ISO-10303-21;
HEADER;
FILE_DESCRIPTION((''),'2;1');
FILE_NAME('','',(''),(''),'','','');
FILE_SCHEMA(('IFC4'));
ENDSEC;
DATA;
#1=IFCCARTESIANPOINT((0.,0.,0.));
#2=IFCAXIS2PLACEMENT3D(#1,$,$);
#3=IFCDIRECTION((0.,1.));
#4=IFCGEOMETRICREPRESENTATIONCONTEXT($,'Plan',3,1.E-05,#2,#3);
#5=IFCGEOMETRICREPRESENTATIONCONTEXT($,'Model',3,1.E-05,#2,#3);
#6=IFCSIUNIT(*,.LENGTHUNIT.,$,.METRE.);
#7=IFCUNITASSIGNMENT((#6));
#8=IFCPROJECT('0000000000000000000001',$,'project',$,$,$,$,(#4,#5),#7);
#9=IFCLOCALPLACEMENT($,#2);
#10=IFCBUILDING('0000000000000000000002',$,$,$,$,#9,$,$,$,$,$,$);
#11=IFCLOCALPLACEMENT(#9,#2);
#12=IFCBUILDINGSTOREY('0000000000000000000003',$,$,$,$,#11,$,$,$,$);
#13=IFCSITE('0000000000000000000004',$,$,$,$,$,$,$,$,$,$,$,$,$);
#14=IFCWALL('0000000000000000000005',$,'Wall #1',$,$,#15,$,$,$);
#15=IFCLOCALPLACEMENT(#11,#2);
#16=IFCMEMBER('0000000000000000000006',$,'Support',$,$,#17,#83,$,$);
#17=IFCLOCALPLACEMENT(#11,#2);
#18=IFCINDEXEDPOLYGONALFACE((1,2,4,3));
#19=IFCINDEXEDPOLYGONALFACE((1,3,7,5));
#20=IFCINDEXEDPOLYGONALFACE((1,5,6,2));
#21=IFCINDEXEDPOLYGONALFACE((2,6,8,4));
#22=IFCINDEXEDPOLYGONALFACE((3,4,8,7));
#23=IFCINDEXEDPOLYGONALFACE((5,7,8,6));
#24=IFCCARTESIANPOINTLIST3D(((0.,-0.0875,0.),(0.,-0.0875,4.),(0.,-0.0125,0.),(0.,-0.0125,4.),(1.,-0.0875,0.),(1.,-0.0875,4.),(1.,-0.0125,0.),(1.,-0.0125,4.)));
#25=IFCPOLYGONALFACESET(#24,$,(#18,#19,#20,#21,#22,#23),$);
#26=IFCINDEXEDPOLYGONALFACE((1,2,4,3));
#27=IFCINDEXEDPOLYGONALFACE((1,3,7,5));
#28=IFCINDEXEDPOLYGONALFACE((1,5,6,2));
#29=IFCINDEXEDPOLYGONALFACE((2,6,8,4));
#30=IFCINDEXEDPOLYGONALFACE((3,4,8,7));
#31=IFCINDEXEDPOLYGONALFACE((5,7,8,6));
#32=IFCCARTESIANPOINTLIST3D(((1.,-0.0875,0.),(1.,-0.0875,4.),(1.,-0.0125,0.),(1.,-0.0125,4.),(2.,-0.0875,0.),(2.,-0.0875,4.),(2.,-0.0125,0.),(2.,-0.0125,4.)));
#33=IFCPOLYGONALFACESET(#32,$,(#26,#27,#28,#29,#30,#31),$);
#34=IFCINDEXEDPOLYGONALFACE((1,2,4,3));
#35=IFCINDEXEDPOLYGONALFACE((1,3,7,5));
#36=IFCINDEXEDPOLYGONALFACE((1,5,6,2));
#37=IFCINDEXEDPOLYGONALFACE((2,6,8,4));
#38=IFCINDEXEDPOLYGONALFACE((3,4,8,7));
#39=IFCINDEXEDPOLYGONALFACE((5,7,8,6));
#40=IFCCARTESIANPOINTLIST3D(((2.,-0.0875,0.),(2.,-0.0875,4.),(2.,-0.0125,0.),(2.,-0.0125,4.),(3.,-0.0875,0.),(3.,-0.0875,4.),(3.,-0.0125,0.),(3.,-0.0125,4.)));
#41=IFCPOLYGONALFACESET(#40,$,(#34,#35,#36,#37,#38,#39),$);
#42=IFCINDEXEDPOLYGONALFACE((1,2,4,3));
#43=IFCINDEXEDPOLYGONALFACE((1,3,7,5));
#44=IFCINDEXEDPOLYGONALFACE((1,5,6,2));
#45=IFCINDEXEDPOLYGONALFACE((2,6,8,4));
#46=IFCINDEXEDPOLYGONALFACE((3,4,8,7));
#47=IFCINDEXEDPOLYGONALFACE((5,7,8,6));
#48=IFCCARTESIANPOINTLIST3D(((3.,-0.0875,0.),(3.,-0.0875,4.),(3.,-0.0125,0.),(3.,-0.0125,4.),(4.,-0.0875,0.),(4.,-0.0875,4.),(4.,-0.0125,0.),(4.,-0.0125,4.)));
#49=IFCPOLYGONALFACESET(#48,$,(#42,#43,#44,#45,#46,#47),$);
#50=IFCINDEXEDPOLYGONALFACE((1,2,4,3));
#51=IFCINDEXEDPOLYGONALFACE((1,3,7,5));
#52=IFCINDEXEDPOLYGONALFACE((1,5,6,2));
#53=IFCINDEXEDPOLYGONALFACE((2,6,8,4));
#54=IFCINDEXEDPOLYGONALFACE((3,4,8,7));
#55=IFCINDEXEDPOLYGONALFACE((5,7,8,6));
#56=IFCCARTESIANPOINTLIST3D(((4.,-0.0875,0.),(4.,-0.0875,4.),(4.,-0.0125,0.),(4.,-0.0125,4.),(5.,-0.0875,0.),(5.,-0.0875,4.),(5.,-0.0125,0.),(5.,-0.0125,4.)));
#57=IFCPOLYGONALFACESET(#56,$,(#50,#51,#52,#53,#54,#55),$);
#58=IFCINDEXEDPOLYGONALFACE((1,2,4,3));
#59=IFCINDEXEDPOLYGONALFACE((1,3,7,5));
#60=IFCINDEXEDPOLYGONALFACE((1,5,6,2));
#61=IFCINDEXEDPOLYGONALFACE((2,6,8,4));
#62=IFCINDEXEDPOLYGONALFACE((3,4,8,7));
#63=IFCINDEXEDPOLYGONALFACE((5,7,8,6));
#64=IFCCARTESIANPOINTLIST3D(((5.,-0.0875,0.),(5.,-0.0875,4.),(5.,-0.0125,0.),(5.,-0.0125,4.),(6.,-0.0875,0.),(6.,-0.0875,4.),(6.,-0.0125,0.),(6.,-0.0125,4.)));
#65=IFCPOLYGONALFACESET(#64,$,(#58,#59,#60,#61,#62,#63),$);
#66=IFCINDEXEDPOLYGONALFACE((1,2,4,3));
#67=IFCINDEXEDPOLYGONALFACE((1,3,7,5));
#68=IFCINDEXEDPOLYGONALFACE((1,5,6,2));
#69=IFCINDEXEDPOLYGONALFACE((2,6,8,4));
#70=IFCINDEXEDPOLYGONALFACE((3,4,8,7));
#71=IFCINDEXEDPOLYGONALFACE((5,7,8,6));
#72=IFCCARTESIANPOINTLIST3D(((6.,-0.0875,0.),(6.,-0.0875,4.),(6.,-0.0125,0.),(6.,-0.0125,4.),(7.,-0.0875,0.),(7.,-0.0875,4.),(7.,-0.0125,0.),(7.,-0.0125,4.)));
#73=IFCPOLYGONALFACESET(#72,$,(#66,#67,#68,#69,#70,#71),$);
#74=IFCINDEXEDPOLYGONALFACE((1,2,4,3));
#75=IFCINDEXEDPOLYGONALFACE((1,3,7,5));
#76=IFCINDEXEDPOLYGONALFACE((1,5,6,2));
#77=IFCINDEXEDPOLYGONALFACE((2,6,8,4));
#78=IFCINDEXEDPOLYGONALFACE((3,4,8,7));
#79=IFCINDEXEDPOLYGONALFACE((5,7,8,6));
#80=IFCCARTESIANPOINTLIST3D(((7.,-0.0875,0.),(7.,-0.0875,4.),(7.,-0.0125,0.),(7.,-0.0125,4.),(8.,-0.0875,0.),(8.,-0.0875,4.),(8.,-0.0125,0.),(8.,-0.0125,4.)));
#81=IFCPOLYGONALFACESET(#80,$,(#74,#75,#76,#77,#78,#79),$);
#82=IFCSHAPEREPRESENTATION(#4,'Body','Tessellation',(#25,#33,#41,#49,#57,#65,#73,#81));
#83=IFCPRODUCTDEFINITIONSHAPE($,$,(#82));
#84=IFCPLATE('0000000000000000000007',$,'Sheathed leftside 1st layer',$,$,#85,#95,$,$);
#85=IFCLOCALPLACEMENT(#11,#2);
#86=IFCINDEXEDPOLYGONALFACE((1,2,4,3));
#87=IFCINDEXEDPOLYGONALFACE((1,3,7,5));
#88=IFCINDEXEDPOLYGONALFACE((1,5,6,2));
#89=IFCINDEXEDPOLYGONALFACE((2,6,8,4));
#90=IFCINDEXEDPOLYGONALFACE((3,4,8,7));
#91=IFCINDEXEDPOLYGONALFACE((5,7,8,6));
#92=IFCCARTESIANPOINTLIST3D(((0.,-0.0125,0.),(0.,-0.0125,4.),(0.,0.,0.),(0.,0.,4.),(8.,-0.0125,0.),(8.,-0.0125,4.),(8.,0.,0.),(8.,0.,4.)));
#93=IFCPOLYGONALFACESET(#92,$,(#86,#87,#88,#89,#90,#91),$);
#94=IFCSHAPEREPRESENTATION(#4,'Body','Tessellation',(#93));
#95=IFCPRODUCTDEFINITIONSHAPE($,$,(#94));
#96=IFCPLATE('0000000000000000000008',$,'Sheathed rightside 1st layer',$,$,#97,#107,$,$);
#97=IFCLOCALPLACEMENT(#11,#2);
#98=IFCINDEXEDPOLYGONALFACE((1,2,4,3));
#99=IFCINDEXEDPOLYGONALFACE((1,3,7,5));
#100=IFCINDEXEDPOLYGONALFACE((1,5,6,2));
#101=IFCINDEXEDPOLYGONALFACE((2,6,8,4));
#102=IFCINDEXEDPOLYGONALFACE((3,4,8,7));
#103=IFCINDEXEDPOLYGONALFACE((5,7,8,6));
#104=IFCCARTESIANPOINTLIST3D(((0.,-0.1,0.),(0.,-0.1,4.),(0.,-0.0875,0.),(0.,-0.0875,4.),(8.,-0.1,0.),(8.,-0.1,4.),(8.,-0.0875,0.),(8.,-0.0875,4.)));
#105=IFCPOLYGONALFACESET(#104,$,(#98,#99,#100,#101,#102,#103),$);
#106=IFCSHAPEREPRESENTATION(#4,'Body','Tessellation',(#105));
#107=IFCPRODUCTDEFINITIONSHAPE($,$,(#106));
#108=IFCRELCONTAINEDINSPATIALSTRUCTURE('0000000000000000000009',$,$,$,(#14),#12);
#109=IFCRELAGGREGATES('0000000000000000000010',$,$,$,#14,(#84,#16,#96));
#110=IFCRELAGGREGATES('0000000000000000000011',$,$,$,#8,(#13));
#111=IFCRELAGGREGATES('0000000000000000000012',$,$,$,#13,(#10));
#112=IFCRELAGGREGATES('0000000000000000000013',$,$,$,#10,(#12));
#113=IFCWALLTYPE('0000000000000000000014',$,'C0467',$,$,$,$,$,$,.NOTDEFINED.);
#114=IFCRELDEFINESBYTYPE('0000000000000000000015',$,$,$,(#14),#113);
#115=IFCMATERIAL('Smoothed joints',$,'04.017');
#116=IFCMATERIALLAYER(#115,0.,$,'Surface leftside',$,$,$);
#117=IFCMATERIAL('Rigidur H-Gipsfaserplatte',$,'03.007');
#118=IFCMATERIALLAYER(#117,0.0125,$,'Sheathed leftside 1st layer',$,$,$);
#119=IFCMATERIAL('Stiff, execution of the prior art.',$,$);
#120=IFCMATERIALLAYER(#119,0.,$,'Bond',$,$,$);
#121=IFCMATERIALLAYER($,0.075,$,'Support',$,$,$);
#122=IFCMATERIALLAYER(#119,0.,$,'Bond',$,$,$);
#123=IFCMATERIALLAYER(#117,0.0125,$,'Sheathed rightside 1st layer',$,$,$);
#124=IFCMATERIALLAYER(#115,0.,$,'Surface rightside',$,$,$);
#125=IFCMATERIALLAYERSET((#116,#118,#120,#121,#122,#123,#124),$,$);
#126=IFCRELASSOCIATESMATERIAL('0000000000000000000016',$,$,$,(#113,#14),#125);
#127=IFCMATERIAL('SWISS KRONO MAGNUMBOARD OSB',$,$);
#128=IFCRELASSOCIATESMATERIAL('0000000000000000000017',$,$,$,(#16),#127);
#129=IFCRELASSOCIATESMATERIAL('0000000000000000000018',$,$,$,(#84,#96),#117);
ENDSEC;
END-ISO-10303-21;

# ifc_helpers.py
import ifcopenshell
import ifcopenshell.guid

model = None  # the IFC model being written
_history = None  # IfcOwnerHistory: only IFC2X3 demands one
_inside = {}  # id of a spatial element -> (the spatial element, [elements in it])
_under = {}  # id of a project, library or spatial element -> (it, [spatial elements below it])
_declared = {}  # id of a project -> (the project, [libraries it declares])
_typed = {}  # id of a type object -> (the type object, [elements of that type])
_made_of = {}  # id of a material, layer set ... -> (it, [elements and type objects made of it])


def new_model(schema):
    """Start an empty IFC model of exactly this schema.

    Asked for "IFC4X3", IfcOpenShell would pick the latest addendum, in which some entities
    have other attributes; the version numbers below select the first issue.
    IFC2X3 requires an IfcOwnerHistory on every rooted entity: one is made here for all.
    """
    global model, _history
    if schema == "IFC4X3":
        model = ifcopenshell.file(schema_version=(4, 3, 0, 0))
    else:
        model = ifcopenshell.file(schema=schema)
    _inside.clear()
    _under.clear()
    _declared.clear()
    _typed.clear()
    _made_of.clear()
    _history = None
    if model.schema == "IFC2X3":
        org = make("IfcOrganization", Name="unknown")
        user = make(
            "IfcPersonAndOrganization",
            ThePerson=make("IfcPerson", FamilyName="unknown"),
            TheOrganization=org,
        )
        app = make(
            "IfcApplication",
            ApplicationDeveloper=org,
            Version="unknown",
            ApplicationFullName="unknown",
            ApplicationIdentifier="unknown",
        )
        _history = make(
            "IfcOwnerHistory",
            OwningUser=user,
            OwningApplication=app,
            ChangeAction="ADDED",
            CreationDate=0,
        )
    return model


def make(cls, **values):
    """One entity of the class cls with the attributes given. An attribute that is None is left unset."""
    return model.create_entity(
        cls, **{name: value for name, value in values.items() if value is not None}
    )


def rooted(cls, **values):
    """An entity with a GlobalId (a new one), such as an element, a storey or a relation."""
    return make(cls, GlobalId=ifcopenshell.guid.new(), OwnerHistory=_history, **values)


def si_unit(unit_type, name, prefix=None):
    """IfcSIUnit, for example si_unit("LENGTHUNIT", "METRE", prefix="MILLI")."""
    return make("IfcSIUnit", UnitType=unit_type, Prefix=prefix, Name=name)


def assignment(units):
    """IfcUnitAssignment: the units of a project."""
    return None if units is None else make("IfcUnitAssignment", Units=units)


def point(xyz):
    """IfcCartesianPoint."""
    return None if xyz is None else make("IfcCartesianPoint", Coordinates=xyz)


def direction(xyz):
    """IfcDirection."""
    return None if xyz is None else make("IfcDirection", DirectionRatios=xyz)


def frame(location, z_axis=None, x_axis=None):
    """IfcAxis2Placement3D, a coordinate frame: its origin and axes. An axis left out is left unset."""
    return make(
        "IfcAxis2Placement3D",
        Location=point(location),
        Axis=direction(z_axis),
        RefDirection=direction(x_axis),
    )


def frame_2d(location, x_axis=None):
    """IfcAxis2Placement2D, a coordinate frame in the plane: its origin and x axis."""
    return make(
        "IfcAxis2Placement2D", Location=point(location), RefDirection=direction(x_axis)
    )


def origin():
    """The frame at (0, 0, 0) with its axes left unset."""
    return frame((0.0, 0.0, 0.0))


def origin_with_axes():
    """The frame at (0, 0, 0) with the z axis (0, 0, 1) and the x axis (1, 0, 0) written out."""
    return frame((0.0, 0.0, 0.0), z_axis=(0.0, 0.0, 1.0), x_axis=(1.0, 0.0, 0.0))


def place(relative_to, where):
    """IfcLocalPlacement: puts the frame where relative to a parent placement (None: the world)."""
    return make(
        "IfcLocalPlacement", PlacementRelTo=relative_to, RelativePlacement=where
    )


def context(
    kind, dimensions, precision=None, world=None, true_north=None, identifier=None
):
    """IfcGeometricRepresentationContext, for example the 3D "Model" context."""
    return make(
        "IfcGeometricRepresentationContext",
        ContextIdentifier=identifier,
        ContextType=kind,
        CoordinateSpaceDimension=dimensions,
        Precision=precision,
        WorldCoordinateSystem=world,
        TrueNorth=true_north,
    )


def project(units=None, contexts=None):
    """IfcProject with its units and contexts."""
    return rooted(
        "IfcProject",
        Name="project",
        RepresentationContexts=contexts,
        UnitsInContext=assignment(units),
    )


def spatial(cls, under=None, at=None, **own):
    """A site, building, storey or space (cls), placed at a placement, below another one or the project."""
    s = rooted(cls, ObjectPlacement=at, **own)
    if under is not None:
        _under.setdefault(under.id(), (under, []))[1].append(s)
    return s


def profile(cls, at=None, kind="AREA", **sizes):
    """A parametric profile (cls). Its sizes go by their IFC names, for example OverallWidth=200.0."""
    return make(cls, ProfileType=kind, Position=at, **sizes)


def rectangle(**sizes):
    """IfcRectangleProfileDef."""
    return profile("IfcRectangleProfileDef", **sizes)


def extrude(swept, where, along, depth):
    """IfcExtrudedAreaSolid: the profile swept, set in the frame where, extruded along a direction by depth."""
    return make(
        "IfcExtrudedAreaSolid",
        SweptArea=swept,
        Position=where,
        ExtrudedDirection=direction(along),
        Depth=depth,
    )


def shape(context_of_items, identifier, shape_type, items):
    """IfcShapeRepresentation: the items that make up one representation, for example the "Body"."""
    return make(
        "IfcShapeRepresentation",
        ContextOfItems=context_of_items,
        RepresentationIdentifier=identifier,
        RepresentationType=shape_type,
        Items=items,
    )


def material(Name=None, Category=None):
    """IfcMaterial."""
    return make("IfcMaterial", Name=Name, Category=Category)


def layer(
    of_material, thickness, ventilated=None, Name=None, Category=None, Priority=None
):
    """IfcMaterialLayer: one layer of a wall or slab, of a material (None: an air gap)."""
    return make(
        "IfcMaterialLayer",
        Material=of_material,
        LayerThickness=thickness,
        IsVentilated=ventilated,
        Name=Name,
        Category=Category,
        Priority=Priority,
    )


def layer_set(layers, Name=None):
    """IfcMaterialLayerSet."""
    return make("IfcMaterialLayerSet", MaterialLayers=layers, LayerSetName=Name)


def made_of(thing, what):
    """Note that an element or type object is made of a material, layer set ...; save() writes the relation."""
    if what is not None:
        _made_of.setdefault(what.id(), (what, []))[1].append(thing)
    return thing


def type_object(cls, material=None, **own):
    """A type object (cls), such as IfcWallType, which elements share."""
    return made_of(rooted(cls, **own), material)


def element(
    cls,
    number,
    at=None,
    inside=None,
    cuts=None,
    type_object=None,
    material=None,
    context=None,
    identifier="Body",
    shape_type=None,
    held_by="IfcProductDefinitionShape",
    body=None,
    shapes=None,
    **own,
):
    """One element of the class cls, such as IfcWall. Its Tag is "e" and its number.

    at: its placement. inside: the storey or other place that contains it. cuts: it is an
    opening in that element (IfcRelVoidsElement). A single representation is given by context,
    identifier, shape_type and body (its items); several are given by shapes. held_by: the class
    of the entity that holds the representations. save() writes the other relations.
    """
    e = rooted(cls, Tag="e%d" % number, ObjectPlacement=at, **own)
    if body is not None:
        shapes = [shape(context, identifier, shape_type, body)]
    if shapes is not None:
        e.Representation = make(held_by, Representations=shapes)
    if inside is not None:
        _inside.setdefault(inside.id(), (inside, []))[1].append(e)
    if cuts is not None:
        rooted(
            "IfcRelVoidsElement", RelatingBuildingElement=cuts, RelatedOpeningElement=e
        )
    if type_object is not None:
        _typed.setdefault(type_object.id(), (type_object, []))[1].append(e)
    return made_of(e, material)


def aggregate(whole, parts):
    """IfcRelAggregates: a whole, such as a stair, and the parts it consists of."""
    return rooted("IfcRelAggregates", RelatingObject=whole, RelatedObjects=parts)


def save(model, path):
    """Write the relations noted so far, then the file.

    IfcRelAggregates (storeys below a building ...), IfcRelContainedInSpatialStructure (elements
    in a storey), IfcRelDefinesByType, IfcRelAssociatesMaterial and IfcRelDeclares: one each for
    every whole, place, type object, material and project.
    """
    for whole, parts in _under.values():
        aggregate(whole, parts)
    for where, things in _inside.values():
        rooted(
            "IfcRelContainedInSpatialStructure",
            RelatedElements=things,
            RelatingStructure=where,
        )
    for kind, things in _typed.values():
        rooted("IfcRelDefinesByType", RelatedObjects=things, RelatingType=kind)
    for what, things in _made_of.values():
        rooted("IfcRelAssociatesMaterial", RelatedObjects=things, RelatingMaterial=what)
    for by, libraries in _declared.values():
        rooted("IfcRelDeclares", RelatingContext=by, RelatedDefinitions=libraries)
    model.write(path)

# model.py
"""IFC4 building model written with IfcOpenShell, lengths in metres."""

from ifc_helpers import new_model, si_unit, direction, frame, frame_2d, origin, origin_with_axes, place, context, project, spatial, rectangle, extrude, material, layer, layer_set, type_object, element, aggregate, save


model = new_model("IFC4")

# Units and contexts
plan_context = context("Plan", 3, precision=1e-05, world=origin(), true_north=direction((0.0, 1.0)))
model_context = context("Model", 3, precision=1e-05, world=origin(), true_north=direction((0.0, 1.0)))
ifc_project = project(units=[si_unit("LENGTHUNIT", "METRE")], contexts=[plan_context, model_context])

# Site, building, storey
site = spatial("IfcSite", under=ifc_project)
building_placement = place(None, origin())
building = spatial("IfcBuilding", under=site, at=building_placement)
storey_placement = place(building_placement, origin())
storey = spatial("IfcBuildingStorey", under=building, at=storey_placement)

# Wall, member, plates
ifc_material_1 = material(Name="Smoothed joints", Category="04.017")
ifc_layer_1 = layer(ifc_material_1, 0.0, Name="Surface leftside")
ifc_material_2 = material(Name="Rigidur H-Gipsfaserplatte", Category="03.007")
ifc_layer_2 = layer(ifc_material_2, 0.0125, Name="Sheathed leftside 1st layer")
ifc_material_3 = material(Name="Stiff, execution of the prior art.")
ifc_layer_3 = layer(ifc_material_3, 0.0, Name="Bond")
ifc_layer_4 = layer(None, 0.075, Name="Support")
ifc_layer_5 = layer(ifc_material_3, 0.0, Name="Bond")
ifc_layer_6 = layer(ifc_material_2, 0.0125, Name="Sheathed rightside 1st layer")
ifc_layer_7 = layer(ifc_material_1, 0.0, Name="Surface rightside")
ifc_layer_set = layer_set([ifc_layer_1, ifc_layer_2, ifc_layer_3, ifc_layer_4, ifc_layer_5, ifc_layer_6, ifc_layer_7])
wall_type = type_object("IfcWallType", Name="C0467", PredefinedType="NOTDEFINED", material=ifc_layer_set)
wall_placement = place(None, frame((0.0, 0.0, 0.0), z_axis=(0.0, -1.0, 0.0), x_axis=(1.0, 0.0, 0.0)))
wall = element("IfcWall", 1, at=wall_placement, inside=storey, type_object=wall_type, material=ifc_layer_set, Name="Wall #1")
ifc_material_4 = material(Name="SWISS KRONO MAGNUMBOARD OSB")
member_placement = place(wall_placement, origin())
member = element("IfcMember", 2, at=member_placement, material=ifc_material_4, Name="Support", context=plan_context, shape_type="SweptSolid", body=[
    extrude(rectangle(XDim=1.0, YDim=0.075, at=frame_2d((0.5, 0.0375), x_axis=(1.0, 0.0))), frame((0.0, 4.0, 0.0125), z_axis=(0.0, -1.0, 0.0), x_axis=(1.0, 0.0, 0.0)), (0.0, 0.0, 1.0), 4.0),
    extrude(rectangle(XDim=1.0, YDim=0.075, at=frame_2d((0.5, 0.0375), x_axis=(1.0, 0.0))), frame((1.0, 4.0, 0.0125), z_axis=(0.0, -1.0, 0.0), x_axis=(1.0, 0.0, 0.0)), (0.0, 0.0, 1.0), 4.0),
    extrude(rectangle(XDim=1.0, YDim=0.075, at=frame_2d((0.5, 0.0375), x_axis=(1.0, 0.0))), frame((2.0, 4.0, 0.0125), z_axis=(0.0, -1.0, 0.0), x_axis=(1.0, 0.0, 0.0)), (0.0, 0.0, 1.0), 4.0),
    extrude(rectangle(XDim=1.0, YDim=0.075, at=frame_2d((0.5, 0.0375), x_axis=(1.0, 0.0))), frame((3.0, 4.0, 0.0125), z_axis=(0.0, -1.0, 0.0), x_axis=(1.0, 0.0, 0.0)), (0.0, 0.0, 1.0), 4.0),
    extrude(rectangle(XDim=1.0, YDim=0.075, at=frame_2d((0.5, 0.0375), x_axis=(1.0, 0.0))), frame((4.0, 4.0, 0.0125), z_axis=(0.0, -1.0, 0.0), x_axis=(1.0, 0.0, 0.0)), (0.0, 0.0, 1.0), 4.0),
    extrude(rectangle(XDim=1.0, YDim=0.075, at=frame_2d((0.5, 0.0375), x_axis=(1.0, 0.0))), frame((5.0, 4.0, 0.0125), z_axis=(0.0, -1.0, 0.0), x_axis=(1.0, 0.0, 0.0)), (0.0, 0.0, 1.0), 4.0),
    extrude(rectangle(XDim=1.0, YDim=0.075, at=frame_2d((0.5, 0.0375), x_axis=(1.0, 0.0))), frame((6.0, 4.0, 0.0125), z_axis=(0.0, -1.0, 0.0), x_axis=(1.0, 0.0, 0.0)), (0.0, 0.0, 1.0), 4.0),
    extrude(rectangle(XDim=1.0, YDim=0.075, at=frame_2d((0.5, 0.0375), x_axis=(1.0, 0.0))), frame((7.0, 4.0, 0.0125), z_axis=(0.0, -1.0, 0.0), x_axis=(1.0, 0.0, 0.0)), (0.0, 0.0, 1.0), 4.0),
])
plate_1_placement = place(wall_placement, origin())
plate_1 = element("IfcPlate", 3, at=plate_1_placement, material=ifc_material_2, Name="Sheathed leftside 1st layer", context=plan_context, shape_type="SweptSolid", body=[
    extrude(rectangle(XDim=8.0, YDim=4.0, at=frame_2d((4.0, 2.0), x_axis=(1.0, 0.0))), origin_with_axes(), (0.0, 0.0, 1.0), 0.0125),
])
plate_2_placement = place(wall_placement, origin())
plate_2 = element("IfcPlate", 4, at=plate_2_placement, material=ifc_material_2, Name="Sheathed rightside 1st layer", context=plan_context, shape_type="SweptSolid", body=[
    extrude(rectangle(XDim=8.0, YDim=4.0, at=frame_2d((4.0, 2.0), x_axis=(1.0, 0.0))), frame((0.0, 0.0, 0.0875), z_axis=(0.0, 0.0, 1.0), x_axis=(1.0, 0.0, 0.0)), (0.0, 0.0, 1.0), 0.0125),
])
aggregate(wall, [plate_1, member, plate_2])

save(model, "model.ifc")
